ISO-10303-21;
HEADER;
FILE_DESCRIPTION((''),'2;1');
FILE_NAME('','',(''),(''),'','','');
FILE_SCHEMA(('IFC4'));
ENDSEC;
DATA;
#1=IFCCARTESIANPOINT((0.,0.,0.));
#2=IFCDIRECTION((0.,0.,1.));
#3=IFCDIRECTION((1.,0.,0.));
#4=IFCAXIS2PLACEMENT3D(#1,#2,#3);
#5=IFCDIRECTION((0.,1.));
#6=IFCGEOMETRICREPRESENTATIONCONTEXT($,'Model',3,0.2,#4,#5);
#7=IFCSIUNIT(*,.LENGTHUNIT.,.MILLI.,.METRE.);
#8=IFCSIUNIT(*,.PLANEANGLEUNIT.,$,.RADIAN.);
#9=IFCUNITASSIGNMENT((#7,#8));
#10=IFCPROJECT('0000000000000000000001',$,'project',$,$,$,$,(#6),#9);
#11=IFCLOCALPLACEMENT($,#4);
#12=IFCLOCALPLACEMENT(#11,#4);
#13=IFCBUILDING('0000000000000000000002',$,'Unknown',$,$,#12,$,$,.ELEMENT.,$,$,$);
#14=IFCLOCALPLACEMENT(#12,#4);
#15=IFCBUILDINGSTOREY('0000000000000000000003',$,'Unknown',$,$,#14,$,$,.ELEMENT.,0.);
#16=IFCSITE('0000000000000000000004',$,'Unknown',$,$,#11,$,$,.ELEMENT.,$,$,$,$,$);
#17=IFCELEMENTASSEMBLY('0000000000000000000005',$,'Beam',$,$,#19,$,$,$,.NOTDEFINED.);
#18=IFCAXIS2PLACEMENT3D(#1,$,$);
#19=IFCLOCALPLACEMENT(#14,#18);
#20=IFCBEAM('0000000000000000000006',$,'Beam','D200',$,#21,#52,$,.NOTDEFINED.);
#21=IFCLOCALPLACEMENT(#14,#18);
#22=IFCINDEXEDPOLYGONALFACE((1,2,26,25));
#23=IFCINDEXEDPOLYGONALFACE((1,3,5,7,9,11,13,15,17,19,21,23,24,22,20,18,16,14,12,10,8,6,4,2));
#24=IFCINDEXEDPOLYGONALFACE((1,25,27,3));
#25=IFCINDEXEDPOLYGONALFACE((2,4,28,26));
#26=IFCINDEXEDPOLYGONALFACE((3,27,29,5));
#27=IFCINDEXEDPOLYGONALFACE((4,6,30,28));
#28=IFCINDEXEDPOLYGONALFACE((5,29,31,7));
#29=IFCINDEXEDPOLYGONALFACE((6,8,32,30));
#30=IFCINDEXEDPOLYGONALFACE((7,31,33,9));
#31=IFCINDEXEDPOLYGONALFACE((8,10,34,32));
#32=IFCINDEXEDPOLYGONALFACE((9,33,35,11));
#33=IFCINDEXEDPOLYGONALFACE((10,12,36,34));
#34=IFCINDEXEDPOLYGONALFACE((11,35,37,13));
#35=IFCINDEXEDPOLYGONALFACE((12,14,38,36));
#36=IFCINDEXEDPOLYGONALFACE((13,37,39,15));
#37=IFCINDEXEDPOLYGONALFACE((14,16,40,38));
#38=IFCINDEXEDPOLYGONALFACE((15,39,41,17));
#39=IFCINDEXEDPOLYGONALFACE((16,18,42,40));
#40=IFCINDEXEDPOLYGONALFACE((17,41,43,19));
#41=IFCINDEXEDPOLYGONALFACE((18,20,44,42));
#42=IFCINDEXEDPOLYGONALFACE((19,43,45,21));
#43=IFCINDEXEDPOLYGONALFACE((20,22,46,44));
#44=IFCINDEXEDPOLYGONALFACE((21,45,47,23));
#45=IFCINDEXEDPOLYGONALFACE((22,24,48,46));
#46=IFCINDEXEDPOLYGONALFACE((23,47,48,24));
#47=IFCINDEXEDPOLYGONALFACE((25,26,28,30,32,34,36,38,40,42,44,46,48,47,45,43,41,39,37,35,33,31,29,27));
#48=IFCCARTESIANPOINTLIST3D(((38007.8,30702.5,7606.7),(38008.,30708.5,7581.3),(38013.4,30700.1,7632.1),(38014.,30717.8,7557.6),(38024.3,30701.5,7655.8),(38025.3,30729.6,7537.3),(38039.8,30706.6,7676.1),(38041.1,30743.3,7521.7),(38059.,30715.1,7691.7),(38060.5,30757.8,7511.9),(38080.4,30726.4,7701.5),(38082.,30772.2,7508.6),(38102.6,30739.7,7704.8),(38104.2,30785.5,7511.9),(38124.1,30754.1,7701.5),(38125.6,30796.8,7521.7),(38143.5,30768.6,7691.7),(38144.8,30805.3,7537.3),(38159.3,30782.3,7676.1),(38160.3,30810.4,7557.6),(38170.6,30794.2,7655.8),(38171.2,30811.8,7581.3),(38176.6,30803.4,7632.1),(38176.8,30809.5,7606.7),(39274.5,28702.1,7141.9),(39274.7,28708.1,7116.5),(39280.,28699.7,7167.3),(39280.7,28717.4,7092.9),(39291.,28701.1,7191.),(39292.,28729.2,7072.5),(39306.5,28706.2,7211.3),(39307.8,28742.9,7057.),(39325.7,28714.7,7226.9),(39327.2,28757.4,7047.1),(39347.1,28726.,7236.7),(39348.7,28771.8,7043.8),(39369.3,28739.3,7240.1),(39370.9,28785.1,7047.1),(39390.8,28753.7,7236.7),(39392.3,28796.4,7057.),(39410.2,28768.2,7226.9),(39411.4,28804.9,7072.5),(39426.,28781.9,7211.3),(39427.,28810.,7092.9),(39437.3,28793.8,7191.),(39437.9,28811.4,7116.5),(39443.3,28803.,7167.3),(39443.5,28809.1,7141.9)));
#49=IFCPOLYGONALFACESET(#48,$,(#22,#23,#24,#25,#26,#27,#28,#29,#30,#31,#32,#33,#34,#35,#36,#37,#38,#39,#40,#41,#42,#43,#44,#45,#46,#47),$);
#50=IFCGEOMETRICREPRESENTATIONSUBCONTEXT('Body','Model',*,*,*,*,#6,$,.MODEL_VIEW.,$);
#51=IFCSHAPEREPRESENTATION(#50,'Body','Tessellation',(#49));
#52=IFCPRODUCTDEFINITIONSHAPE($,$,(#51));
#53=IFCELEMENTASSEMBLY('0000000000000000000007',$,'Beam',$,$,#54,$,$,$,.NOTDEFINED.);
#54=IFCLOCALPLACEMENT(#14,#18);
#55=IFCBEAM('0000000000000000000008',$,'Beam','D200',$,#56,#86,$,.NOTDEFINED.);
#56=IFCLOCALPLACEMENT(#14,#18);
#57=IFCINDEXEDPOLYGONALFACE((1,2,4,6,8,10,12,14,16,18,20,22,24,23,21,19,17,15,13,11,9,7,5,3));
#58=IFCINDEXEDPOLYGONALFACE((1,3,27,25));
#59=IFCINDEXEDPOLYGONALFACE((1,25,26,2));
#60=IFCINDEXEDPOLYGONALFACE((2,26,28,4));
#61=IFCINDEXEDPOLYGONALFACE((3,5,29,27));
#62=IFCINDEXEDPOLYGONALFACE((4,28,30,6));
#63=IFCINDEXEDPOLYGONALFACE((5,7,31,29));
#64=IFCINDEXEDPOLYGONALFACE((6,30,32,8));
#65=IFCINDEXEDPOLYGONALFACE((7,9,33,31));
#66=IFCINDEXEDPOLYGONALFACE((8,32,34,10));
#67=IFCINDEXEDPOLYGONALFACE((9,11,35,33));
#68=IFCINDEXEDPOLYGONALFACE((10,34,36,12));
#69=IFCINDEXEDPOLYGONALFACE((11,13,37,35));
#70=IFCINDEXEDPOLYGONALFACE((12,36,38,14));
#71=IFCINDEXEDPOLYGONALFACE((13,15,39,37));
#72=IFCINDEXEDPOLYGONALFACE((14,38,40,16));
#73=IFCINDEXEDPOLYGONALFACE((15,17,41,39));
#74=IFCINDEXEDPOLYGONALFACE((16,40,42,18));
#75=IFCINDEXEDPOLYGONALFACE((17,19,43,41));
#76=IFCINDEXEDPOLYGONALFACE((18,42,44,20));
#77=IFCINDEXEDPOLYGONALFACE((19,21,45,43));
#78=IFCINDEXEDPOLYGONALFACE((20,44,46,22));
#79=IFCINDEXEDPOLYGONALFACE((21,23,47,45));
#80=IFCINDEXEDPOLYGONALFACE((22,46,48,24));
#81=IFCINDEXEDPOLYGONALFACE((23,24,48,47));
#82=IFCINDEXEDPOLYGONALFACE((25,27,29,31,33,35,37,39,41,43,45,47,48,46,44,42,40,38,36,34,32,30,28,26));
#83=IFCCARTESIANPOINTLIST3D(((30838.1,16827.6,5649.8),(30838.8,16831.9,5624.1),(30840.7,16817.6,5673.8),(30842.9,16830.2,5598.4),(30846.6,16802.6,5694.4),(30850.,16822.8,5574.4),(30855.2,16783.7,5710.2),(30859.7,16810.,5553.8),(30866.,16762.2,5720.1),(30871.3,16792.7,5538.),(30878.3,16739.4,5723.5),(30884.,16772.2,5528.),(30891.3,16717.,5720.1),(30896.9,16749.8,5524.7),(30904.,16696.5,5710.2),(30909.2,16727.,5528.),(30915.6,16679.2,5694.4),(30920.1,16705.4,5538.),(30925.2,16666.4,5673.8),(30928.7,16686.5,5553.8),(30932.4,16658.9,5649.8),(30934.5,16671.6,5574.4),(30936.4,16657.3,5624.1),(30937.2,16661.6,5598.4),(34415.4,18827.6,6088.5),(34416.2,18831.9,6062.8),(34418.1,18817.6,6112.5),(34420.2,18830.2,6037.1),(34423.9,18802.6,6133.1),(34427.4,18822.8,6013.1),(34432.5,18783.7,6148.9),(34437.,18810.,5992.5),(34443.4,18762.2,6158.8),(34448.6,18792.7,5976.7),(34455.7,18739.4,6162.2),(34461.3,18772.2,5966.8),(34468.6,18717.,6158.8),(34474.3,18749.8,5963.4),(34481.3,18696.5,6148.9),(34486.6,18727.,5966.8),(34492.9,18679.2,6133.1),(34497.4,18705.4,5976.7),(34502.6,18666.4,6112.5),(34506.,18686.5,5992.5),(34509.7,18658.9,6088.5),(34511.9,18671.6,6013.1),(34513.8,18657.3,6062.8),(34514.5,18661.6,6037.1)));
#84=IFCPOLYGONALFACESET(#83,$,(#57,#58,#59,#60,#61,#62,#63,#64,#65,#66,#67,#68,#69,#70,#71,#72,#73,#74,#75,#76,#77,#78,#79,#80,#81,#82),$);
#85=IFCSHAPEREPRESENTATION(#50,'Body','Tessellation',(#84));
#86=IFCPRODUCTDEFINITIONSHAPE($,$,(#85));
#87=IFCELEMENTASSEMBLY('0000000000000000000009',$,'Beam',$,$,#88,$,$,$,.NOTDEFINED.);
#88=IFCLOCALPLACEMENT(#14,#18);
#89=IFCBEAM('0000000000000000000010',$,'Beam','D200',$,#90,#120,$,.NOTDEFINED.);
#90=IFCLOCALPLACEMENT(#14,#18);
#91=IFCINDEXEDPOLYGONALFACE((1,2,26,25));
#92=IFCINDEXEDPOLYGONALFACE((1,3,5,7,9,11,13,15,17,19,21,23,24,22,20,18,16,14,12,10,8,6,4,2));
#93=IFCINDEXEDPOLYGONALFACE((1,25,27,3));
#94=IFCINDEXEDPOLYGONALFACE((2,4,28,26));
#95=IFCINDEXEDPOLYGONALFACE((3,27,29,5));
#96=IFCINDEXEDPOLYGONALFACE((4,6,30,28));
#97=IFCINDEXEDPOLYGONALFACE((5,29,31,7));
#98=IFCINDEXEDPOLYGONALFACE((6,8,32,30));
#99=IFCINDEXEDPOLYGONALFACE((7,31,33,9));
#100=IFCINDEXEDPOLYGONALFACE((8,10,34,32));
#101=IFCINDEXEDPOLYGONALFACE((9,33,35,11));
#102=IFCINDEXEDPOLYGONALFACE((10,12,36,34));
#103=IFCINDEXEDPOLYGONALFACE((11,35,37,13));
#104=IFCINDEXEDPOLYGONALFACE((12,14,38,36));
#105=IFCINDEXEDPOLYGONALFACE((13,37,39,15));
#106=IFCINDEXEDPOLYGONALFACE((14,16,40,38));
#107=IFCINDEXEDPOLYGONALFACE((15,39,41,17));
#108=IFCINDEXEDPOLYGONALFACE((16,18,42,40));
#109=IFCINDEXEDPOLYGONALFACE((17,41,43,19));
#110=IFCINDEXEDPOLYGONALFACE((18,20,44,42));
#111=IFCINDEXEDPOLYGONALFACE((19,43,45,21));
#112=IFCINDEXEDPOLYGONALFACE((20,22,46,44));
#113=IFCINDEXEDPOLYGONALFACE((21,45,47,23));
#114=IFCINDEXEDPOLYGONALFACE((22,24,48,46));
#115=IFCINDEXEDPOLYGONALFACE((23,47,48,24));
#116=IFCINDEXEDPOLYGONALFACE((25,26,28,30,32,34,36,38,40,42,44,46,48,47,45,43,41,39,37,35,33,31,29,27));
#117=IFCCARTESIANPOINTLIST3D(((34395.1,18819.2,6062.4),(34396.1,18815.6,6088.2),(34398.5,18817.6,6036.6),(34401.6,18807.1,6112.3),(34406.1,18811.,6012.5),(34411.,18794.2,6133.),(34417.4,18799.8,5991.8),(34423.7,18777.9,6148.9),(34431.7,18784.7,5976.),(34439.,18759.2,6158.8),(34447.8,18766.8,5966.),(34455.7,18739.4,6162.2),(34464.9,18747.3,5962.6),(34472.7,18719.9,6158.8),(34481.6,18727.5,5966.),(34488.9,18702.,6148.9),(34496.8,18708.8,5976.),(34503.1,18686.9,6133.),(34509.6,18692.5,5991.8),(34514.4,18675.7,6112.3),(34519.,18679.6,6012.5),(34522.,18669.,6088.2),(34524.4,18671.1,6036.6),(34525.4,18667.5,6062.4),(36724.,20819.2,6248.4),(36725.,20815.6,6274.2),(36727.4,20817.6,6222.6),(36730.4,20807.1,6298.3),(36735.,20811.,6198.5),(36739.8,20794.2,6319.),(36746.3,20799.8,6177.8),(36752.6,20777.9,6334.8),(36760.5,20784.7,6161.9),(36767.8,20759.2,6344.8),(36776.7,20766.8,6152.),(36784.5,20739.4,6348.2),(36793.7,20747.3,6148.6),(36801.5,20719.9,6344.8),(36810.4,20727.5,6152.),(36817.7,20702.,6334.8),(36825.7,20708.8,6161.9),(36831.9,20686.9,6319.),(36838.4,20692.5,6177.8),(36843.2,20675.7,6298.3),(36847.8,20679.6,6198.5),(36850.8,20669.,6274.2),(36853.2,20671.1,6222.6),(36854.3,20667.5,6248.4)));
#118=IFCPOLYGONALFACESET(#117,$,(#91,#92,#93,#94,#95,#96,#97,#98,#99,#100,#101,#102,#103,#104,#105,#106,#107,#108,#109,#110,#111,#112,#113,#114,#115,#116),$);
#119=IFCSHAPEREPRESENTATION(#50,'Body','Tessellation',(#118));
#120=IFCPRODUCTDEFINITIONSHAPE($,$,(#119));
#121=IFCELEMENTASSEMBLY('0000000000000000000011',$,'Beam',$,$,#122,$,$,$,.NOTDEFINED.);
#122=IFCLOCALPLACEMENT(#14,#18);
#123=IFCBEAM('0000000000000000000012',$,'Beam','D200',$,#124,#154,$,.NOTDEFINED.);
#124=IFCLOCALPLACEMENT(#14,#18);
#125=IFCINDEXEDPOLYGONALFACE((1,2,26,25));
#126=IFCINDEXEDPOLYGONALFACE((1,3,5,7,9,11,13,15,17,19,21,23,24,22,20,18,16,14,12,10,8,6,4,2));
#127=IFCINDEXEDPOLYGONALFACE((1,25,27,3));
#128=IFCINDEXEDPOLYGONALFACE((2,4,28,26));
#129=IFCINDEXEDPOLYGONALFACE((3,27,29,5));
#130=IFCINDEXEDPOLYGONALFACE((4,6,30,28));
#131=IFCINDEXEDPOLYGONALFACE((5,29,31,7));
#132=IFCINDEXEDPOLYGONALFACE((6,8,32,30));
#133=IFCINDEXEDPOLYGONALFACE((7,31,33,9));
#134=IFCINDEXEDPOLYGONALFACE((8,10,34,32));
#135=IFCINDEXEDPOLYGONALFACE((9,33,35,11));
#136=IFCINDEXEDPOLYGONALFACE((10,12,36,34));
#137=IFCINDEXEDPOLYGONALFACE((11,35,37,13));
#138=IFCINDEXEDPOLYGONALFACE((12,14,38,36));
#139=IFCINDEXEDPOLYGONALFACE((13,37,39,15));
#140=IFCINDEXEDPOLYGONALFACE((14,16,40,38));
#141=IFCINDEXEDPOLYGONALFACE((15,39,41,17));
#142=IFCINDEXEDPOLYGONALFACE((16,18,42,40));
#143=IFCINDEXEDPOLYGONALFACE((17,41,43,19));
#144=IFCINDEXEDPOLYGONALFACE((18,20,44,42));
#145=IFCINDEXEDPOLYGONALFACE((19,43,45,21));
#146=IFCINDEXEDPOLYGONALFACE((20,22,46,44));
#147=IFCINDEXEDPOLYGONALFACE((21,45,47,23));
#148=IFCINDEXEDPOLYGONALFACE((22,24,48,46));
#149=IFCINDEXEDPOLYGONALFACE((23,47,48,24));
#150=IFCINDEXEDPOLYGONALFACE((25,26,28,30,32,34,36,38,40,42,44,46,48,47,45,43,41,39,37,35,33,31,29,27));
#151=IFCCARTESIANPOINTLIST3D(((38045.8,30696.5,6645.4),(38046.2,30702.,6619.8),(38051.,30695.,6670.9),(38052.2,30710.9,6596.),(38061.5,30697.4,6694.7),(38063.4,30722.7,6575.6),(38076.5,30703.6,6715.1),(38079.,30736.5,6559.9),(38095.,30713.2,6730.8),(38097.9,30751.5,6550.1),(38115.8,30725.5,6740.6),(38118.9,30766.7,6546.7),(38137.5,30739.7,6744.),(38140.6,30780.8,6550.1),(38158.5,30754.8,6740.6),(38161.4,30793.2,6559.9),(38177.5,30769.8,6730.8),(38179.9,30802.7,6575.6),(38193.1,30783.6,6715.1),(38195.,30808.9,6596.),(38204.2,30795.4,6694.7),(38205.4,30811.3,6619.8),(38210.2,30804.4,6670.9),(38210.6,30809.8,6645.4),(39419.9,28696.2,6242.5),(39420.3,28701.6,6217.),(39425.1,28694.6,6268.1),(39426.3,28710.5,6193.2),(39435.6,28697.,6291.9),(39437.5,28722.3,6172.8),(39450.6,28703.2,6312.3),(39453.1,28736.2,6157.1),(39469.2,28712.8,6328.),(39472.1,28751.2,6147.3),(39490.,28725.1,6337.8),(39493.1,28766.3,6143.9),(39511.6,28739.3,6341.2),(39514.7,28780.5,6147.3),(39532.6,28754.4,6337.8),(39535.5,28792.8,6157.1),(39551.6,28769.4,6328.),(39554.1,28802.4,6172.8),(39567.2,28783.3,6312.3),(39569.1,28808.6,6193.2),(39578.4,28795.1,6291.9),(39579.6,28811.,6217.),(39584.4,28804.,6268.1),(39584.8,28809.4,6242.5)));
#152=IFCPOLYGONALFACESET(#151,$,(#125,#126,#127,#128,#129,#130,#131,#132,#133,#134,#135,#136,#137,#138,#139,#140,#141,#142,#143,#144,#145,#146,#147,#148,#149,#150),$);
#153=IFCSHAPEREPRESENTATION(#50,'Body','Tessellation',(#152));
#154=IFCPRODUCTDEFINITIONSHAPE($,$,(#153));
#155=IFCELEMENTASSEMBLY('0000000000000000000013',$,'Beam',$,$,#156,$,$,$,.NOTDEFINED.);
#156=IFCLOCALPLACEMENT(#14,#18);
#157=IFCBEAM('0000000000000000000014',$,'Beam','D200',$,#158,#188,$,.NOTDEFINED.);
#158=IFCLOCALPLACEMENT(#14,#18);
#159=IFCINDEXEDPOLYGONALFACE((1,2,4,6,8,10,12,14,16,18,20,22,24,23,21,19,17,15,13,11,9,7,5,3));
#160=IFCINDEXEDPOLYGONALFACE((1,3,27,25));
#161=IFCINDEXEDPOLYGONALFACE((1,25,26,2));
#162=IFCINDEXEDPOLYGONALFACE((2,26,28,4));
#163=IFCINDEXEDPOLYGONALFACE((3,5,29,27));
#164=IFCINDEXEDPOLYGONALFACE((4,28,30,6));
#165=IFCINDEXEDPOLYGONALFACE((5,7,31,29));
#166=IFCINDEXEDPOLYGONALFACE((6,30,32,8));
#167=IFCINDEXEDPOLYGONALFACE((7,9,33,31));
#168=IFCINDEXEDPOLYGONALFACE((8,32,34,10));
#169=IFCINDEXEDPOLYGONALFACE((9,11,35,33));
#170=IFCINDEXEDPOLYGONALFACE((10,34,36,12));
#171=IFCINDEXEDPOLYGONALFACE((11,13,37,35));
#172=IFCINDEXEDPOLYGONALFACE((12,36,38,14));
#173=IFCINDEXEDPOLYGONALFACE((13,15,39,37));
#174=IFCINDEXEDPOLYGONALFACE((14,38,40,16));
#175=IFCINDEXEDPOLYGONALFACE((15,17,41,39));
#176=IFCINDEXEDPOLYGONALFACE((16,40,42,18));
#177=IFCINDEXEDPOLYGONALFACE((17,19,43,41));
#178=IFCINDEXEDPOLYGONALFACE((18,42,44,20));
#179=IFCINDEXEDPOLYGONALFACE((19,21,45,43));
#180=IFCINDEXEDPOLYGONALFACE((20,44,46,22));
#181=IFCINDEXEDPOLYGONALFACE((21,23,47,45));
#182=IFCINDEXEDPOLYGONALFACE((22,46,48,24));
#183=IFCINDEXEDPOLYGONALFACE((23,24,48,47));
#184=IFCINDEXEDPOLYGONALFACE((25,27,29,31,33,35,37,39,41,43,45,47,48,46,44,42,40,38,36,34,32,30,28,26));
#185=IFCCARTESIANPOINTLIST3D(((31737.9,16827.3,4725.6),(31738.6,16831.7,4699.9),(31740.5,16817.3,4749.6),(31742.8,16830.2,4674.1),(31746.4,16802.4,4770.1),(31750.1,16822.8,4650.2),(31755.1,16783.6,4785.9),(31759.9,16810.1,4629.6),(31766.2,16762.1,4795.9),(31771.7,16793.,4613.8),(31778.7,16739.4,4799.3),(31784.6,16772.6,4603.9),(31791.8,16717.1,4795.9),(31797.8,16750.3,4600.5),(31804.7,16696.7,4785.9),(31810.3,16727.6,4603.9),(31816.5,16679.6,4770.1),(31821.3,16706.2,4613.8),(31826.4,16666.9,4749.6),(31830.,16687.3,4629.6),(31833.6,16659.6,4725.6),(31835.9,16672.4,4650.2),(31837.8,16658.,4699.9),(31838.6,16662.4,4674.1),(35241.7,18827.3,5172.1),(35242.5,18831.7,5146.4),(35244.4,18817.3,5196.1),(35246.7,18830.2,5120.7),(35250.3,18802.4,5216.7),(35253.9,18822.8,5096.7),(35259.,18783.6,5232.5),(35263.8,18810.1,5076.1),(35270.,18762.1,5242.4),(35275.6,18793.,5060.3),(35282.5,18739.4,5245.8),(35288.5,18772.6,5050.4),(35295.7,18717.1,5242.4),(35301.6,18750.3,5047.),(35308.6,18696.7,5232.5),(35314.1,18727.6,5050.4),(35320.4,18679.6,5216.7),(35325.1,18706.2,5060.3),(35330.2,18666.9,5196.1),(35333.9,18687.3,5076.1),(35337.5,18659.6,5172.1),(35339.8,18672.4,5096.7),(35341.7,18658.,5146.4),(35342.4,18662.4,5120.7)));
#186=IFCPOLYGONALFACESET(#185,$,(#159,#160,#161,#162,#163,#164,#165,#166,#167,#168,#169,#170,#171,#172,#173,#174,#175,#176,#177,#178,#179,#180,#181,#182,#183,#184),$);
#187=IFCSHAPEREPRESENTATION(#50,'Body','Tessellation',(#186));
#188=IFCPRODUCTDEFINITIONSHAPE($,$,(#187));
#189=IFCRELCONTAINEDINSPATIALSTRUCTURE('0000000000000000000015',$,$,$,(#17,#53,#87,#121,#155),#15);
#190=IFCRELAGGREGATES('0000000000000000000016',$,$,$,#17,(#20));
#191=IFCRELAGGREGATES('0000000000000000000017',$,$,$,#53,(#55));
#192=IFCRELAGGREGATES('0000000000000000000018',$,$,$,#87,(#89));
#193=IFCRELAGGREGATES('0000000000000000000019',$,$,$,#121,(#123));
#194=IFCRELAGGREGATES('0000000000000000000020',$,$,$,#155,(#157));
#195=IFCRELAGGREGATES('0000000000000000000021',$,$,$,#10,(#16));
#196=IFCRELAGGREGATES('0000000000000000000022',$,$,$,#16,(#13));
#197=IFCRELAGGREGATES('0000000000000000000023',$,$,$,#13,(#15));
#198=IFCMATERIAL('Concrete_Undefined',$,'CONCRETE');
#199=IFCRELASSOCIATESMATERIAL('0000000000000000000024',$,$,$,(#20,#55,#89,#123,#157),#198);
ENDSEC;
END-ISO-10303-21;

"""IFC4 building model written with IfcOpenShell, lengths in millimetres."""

from ifc_helpers import new_model, si_unit, direction, frame, origin_with_axes, place, context, subcontext, project, spatial, line, indexed_curve, outline, extrude, material, element, aggregate, save


model = new_model("IFC4")

# Units and contexts
model_context = context("Model", 3, precision=0.2, world=origin_with_axes(), true_north=direction((0.0, 1.0)))
body_context = subcontext(model_context, "Body", "Model", "MODEL_VIEW")
ifc_project = project(units=[si_unit("LENGTHUNIT", "METRE", prefix="MILLI"), si_unit("PLANEANGLEUNIT", "RADIAN")], contexts=[model_context])

# Site, building, storey
site_placement = place(None, origin_with_axes())
site = spatial("IfcSite", under=ifc_project, at=site_placement, Name="Unknown", CompositionType="ELEMENT")
building_placement = place(site_placement, origin_with_axes())
building = spatial("IfcBuilding", under=site, at=building_placement, Name="Unknown", CompositionType="ELEMENT")
storey_placement = place(building_placement, origin_with_axes())
storey = spatial("IfcBuildingStorey", under=building, at=storey_placement, Name="Unknown", CompositionType="ELEMENT", Elevation=0.0)

# Element assemblies, beams
ifc_material = material(Name="Concrete_Undefined", Category="CONCRETE")
assembly_1_placement = place(storey_placement, frame((38092.3, 30756.0, 7606.7), z_axis=(-0.844863, -0.534982, 0.0), x_axis=(0.524964, -0.829042, -0.192617)))
assembly_1 = element("IfcElementAssembly", 1, at=assembly_1_placement, inside=storey, Name="Beam", PredefinedType="NOTDEFINED")
beam_1_placement = place(assembly_1_placement, origin_with_axes())
beam_1 = element("IfcBeam", 2, at=beam_1_placement, material=ifc_material, Name="Beam", Description="D200", PredefinedType="NOTDEFINED", context=body_context, shape_type="SolidModel", body=[
    extrude(outline(indexed_curve([(100.0, 0.0), (96.6, 25.9), (86.6, 50.0), (70.7, 70.7), (50.0, 86.6), (25.9, 96.6), (0.0, 100.0), (-25.9, 96.6), (-50.0, 86.6), (-70.7, 70.7), (-86.6, 50.0), (-96.6, 25.9), (-100.0, 0.0), (-96.6, -25.9), (-86.6, -50.0), (-70.7, -70.7), (-50.0, -86.6), (-25.9, -96.6), (0.0, -100.0), (25.9, -96.6), (50.0, -86.6), (70.7, -70.7), (86.6, -50.0), (96.6, -25.9)], segments=[line(1, 2, 3, 4, 5, 6, 7, 8, 9, 10, 11, 12, 13, 14, 15, 16, 17, 18, 19, 20, 21, 22, 23, 24, 1)])), frame((0.0, 0.0, 0.0), z_axis=(-1.0, 0.0, 0.0), x_axis=(0.0, 0.0, 1.0)), (0.0, 0.0, -1.0), 2412.9),
])
aggregate(assembly_1, [beam_1])
assembly_2_placement = place(storey_placement, frame((34465.0, 18744.6, 6062.8), z_axis=(-0.487988, 0.87285, 0.0), x_axis=(-0.867892, -0.485216, -0.106435)))
assembly_2 = element("IfcElementAssembly", 3, at=assembly_2_placement, inside=storey, Name="Beam", PredefinedType="NOTDEFINED")
beam_2_placement = place(assembly_2_placement, origin_with_axes())
beam_2 = element("IfcBeam", 4, at=beam_2_placement, material=ifc_material, Name="Beam", Description="D200", PredefinedType="NOTDEFINED", context=body_context, shape_type="SolidModel", body=[
    extrude(outline(indexed_curve([(100.0, 0.0), (96.6, 25.9), (86.6, 50.0), (70.7, 70.7), (50.0, 86.6), (25.9, 96.6), (0.0, 100.0), (-25.9, 96.6), (-50.0, 86.6), (-70.7, 70.7), (-86.6, 50.0), (-96.6, 25.9), (-100.0, 0.0), (-96.6, -25.9), (-86.6, -50.0), (-70.7, -70.7), (-50.0, -86.6), (-25.9, -96.6), (0.0, -100.0), (25.9, -96.6), (50.0, -86.6), (70.7, -70.7), (86.6, -50.0), (96.6, -25.9)], segments=[line(1, 2, 3, 4, 5, 6, 7, 8, 9, 10, 11, 12, 13, 14, 15, 16, 17, 18, 19, 20, 21, 22, 23, 24, 1)])), frame((0.0, 0.0, 0.0), z_axis=(-1.0, 0.0, 0.0), x_axis=(0.0, 0.0, 1.0)), (0.0, 0.0, -1.0), 4121.9),
])
aggregate(assembly_2, [beam_2])
assembly_3_placement = place(storey_placement, frame((36789.1, 20743.3, 6248.4), z_axis=(-0.651515, 0.758636, 0.0), x_axis=(-0.757247, -0.650323, -0.060472)))
assembly_3 = element("IfcElementAssembly", 5, at=assembly_3_placement, inside=storey, Name="Beam", PredefinedType="NOTDEFINED")
beam_3_placement = place(assembly_3_placement, origin_with_axes())
beam_3 = element("IfcBeam", 6, at=beam_3_placement, material=ifc_material, Name="Beam", Description="D200", PredefinedType="NOTDEFINED", context=body_context, shape_type="SolidModel", body=[
    extrude(outline(indexed_curve([(100.0, 0.0), (96.6, 25.9), (86.6, 50.0), (70.7, 70.7), (50.0, 86.6), (25.9, 96.6), (0.0, 100.0), (-25.9, 96.6), (-50.0, 86.6), (-70.7, 70.7), (-86.6, 50.0), (-96.6, 25.9), (-100.0, 0.0), (-96.6, -25.9), (-86.6, -50.0), (-70.7, -70.7), (-50.0, -86.6), (-25.9, -96.6), (0.0, -100.0), (25.9, -96.6), (50.0, -86.6), (70.7, -70.7), (86.6, -50.0), (96.6, -25.9)], segments=[line(1, 2, 3, 4, 5, 6, 7, 8, 9, 10, 11, 12, 13, 14, 15, 16, 17, 18, 19, 20, 21, 22, 23, 24, 1)])), frame((0.0, 0.0, 0.0), z_axis=(-1.0, 0.0, 0.0), x_axis=(0.0, 0.0, 1.0)), (0.0, 0.0, -1.0), 3075.4),
])
aggregate(assembly_3, [beam_3])
assembly_4_placement = place(storey_placement, frame((38128.2, 30753.2, 6645.4), z_axis=(-0.824255, -0.566218, 0.0), x_axis=(0.558577, -0.813131, -0.163737)))
assembly_4 = element("IfcElementAssembly", 7, at=assembly_4_placement, inside=storey, Name="Beam", PredefinedType="NOTDEFINED")
beam_4_placement = place(assembly_4_placement, origin_with_axes())
beam_4 = element("IfcBeam", 8, at=beam_4_placement, material=ifc_material, Name="Beam", Description="D200", PredefinedType="NOTDEFINED", context=body_context, shape_type="SolidModel", body=[
    extrude(outline(indexed_curve([(100.0, 0.0), (96.6, 25.9), (86.6, 50.0), (70.7, 70.7), (50.0, 86.6), (25.9, 96.6), (0.0, 100.0), (-25.9, 96.6), (-50.0, 86.6), (-70.7, 70.7), (-86.6, 50.0), (-96.6, 25.9), (-100.0, 0.0), (-96.6, -25.9), (-86.6, -50.0), (-70.7, -70.7), (-50.0, -86.6), (-25.9, -96.6), (0.0, -100.0), (25.9, -96.6), (50.0, -86.6), (70.7, -70.7), (86.6, -50.0), (96.6, -25.9)], segments=[line(1, 2, 3, 4, 5, 6, 7, 8, 9, 10, 11, 12, 13, 14, 15, 16, 17, 18, 19, 20, 21, 22, 23, 24, 1)])), frame((0.0, 0.0, 0.0), z_axis=(-1.0, 0.0, 0.0), x_axis=(0.0, 0.0, 1.0)), (0.0, 0.0, -1.0), 2460.1),
])
aggregate(assembly_4, [beam_4])
assembly_5_placement = place(storey_placement, frame((35292.1, 18744.9, 5146.4), z_axis=(-0.495726, 0.868479, 0.0), x_axis=(-0.863208, -0.492717, -0.110012)))
assembly_5 = element("IfcElementAssembly", 9, at=assembly_5_placement, inside=storey, Name="Beam", PredefinedType="NOTDEFINED")
beam_5_placement = place(assembly_5_placement, origin_with_axes())
beam_5 = element("IfcBeam", 10, at=beam_5_placement, material=ifc_material, Name="Beam", Description="D200", PredefinedType="NOTDEFINED", context=body_context, shape_type="SolidModel", body=[
    extrude(outline(indexed_curve([(100.0, 0.0), (96.6, 25.9), (86.6, 50.0), (70.7, 70.7), (50.0, 86.6), (25.9, 96.6), (0.0, 100.0), (-25.9, 96.6), (-50.0, 86.6), (-70.7, 70.7), (-86.6, 50.0), (-96.6, 25.9), (-100.0, 0.0), (-96.6, -25.9), (-86.6, -50.0), (-70.7, -70.7), (-50.0, -86.6), (-25.9, -96.6), (0.0, -100.0), (25.9, -96.6), (50.0, -86.6), (70.7, -70.7), (86.6, -50.0), (96.6, -25.9)], segments=[line(1, 2, 3, 4, 5, 6, 7, 8, 9, 10, 11, 12, 13, 14, 15, 16, 17, 18, 19, 20, 21, 22, 23, 24, 1)])), frame((0.0, 0.0, 0.0), z_axis=(-1.0, 0.0, 0.0), x_axis=(0.0, 0.0, 1.0)), (0.0, 0.0, -1.0), 4059.1),
])
aggregate(assembly_5, [beam_5])

save(model, "model.ifc")
